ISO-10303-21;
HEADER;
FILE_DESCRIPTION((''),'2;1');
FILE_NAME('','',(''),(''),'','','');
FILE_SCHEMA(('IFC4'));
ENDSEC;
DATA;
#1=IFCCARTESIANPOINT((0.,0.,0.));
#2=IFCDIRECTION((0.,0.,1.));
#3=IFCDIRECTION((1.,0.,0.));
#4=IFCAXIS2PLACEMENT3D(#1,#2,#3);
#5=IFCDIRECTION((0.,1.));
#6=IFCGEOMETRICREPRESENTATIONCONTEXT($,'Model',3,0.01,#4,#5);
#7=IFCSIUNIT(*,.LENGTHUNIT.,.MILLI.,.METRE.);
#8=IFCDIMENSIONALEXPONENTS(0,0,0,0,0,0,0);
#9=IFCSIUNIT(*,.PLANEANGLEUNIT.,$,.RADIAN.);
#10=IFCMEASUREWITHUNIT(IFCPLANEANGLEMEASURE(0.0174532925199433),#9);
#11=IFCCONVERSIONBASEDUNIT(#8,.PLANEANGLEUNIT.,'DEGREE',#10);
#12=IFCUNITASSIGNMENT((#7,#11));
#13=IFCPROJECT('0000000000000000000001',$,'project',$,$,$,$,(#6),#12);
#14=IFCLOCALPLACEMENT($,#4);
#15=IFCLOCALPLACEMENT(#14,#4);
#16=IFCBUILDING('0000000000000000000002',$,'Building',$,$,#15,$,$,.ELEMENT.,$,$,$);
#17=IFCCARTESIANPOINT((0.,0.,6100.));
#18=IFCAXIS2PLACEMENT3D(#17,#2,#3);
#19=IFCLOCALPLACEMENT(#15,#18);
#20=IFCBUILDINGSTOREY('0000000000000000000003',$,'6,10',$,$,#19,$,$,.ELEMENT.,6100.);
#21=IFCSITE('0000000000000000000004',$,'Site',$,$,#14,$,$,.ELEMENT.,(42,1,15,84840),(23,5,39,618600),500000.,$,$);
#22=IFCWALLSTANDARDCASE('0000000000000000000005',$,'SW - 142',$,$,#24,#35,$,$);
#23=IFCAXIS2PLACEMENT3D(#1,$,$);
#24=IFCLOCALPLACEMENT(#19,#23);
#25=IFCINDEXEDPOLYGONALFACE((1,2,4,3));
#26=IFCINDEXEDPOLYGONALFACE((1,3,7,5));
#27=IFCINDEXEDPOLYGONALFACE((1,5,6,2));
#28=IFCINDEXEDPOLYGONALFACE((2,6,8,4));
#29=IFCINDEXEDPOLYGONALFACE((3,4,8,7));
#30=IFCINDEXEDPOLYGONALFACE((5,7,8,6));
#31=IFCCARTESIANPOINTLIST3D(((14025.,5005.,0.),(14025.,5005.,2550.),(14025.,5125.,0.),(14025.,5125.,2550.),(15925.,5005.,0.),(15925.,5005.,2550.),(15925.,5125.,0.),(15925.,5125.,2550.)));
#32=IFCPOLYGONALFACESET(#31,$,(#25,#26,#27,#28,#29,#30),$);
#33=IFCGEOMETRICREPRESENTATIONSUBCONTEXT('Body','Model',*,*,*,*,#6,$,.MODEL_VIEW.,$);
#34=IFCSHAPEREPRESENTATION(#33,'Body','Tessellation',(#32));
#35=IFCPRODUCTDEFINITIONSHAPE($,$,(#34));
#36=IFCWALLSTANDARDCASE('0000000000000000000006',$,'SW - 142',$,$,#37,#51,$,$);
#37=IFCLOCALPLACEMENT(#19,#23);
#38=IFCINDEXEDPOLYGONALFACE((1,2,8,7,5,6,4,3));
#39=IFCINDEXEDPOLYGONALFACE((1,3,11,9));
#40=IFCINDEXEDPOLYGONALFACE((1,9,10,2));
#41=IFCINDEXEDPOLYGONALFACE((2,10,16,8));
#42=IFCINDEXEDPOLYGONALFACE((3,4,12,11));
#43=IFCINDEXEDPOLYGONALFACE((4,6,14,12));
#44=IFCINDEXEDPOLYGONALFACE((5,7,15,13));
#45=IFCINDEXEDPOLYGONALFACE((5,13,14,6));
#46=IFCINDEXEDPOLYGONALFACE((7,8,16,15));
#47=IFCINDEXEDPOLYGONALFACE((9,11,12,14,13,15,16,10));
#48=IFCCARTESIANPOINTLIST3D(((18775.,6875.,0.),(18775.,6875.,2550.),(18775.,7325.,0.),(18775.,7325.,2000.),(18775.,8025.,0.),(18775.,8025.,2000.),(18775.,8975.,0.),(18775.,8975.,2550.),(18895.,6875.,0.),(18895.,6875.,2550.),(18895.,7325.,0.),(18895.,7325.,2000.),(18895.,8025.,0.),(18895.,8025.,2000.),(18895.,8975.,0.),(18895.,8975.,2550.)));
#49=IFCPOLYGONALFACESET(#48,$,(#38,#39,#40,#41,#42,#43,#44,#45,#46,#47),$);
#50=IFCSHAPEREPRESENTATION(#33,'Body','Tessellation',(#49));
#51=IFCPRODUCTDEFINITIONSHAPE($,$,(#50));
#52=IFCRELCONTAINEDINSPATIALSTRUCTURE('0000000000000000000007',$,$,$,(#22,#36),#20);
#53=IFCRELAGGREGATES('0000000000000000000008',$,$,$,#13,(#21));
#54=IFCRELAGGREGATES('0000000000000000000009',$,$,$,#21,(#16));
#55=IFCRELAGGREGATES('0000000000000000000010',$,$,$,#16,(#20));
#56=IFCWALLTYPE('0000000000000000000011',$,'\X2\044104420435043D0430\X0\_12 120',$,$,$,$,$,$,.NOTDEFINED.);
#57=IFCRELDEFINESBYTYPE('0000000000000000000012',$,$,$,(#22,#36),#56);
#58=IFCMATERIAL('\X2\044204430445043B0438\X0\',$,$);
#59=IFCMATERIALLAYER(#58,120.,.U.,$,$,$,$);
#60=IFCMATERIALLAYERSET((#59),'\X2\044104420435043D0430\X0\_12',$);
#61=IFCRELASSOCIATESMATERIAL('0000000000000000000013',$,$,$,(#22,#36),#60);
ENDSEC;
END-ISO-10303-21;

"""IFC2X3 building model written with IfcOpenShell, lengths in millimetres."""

from ifc_helpers import new_model, entity, si_unit, converted_unit, direction, frame, origin_with_axes, origin_2d_with_axis, place, context, subcontext, project, spatial, polyline, rectangle, outline, extrude, material, layer, layer_set, layer_usage, type_object, element, save


model = new_model("IFC2X3")

# Units and contexts
model_context = context("Model", 3, precision=0.01, world=origin_with_axes(), true_north=direction((0.0, 1.0)))
body_context = subcontext(model_context, "Body", "Model", "MODEL_VIEW")
ifc_project = project(units=[si_unit("LENGTHUNIT", "METRE", prefix="MILLI"), converted_unit("PLANEANGLEUNIT", "DEGREE", entity("IfcPlaneAngleMeasure", 0.0174532925199433), si_unit("PLANEANGLEUNIT", "RADIAN"), dimensions=[0, 0, 0, 0, 0, 0, 0])], contexts=[model_context])

# Site, building, storey
site_placement = place(None, origin_with_axes())
site = spatial("IfcSite", under=ifc_project, at=site_placement, Name="Site", CompositionType="ELEMENT", RefLatitude=(42, 1, 15, 84840), RefLongitude=(23, 5, 39, 618600), RefElevation=500000.0)
building_placement = place(site_placement, origin_with_axes())
building = spatial("IfcBuilding", under=site, at=building_placement, Name="Building", CompositionType="ELEMENT")
storey_placement = place(building_placement, frame((0.0, 0.0, 6100.0), z_axis=(0.0, 0.0, 1.0), x_axis=(1.0, 0.0, 0.0)))
storey = spatial("IfcBuildingStorey", under=building, at=storey_placement, Name="6,10", CompositionType="ELEMENT", Elevation=6100.0)

# Shared definitions
ifc_material_1 = material(Name="тухли")

# Shared definitions
ifc_layer_1 = layer(ifc_material_1, 120.0, ventilated="UNKNOWN")
ifc_layer_set_1 = layer_set([ifc_layer_1], Name="стена_12")
wall_type_1 = type_object("IfcWallType", Name="стена_12 120", PredefinedType="NOTDEFINED")

# Wall
ifc_layer_usage_1 = layer_usage(ifc_layer_set_1, "AXIS2", "NEGATIVE", 60.0)
wall_1_placement = place(storey_placement, frame((14025.0, 5065.0, 0.0), z_axis=(0.0, 0.0, 1.0), x_axis=(1.0, 0.0, 0.0)))
element("IfcWallStandardCase", 1, at=wall_1_placement, inside=storey, type_object=wall_type_1, material=ifc_layer_usage_1, Name="SW - 142", context=body_context, shape_type="SweptSolid", body=[
    extrude(outline(polyline([(0.0, -60.0), (1900.0, -60.0), (1900.0, 60.0), (0.0, 60.0), (0.0, -60.0)])), origin_with_axes(), (0.0, 0.0, 1.0), 2550.0),
])

# Wall, opening
ifc_layer_usage_2 = layer_usage(ifc_layer_set_1, "AXIS2", "POSITIVE", -60.0)
wall_2_placement = place(storey_placement, frame((18835.0, 8975.0, 0.0), z_axis=(0.0, 0.0, 1.0), x_axis=(0.0, -1.0, 0.0)))
wall_2 = element("IfcWallStandardCase", 2, at=wall_2_placement, inside=storey, type_object=wall_type_1, material=ifc_layer_usage_2, Name="SW - 142", context=body_context, shape_type="SweptSolid", body=[
    extrude(outline(polyline([(0.0, -60.0), (2100.0, -60.0), (2100.0, 60.0), (0.0, 60.0), (0.0, -60.0)])), origin_with_axes(), (0.0, 0.0, 1.0), 2550.0),
])
opening_1_placement = place(wall_2_placement, frame((1300.0, 0.0, 0.0), z_axis=(0.0, 0.0, 1.0), x_axis=(1.0, 0.0, 0.0)))
element("IfcOpeningElement", 3, at=opening_1_placement, cuts=wall_2, context=body_context, shape_type="SweptSolid", body=[
    extrude(rectangle(XDim=700.0, YDim=2000.0, at=origin_2d_with_axis()), frame((0.0, -120.0, 1000.0), z_axis=(0.0, -1.0, 0.0), x_axis=(-1.0, 0.0, 0.0)), (0.0, 0.0, -1.0), 360.0),
])

save(model, "model.ifc")
